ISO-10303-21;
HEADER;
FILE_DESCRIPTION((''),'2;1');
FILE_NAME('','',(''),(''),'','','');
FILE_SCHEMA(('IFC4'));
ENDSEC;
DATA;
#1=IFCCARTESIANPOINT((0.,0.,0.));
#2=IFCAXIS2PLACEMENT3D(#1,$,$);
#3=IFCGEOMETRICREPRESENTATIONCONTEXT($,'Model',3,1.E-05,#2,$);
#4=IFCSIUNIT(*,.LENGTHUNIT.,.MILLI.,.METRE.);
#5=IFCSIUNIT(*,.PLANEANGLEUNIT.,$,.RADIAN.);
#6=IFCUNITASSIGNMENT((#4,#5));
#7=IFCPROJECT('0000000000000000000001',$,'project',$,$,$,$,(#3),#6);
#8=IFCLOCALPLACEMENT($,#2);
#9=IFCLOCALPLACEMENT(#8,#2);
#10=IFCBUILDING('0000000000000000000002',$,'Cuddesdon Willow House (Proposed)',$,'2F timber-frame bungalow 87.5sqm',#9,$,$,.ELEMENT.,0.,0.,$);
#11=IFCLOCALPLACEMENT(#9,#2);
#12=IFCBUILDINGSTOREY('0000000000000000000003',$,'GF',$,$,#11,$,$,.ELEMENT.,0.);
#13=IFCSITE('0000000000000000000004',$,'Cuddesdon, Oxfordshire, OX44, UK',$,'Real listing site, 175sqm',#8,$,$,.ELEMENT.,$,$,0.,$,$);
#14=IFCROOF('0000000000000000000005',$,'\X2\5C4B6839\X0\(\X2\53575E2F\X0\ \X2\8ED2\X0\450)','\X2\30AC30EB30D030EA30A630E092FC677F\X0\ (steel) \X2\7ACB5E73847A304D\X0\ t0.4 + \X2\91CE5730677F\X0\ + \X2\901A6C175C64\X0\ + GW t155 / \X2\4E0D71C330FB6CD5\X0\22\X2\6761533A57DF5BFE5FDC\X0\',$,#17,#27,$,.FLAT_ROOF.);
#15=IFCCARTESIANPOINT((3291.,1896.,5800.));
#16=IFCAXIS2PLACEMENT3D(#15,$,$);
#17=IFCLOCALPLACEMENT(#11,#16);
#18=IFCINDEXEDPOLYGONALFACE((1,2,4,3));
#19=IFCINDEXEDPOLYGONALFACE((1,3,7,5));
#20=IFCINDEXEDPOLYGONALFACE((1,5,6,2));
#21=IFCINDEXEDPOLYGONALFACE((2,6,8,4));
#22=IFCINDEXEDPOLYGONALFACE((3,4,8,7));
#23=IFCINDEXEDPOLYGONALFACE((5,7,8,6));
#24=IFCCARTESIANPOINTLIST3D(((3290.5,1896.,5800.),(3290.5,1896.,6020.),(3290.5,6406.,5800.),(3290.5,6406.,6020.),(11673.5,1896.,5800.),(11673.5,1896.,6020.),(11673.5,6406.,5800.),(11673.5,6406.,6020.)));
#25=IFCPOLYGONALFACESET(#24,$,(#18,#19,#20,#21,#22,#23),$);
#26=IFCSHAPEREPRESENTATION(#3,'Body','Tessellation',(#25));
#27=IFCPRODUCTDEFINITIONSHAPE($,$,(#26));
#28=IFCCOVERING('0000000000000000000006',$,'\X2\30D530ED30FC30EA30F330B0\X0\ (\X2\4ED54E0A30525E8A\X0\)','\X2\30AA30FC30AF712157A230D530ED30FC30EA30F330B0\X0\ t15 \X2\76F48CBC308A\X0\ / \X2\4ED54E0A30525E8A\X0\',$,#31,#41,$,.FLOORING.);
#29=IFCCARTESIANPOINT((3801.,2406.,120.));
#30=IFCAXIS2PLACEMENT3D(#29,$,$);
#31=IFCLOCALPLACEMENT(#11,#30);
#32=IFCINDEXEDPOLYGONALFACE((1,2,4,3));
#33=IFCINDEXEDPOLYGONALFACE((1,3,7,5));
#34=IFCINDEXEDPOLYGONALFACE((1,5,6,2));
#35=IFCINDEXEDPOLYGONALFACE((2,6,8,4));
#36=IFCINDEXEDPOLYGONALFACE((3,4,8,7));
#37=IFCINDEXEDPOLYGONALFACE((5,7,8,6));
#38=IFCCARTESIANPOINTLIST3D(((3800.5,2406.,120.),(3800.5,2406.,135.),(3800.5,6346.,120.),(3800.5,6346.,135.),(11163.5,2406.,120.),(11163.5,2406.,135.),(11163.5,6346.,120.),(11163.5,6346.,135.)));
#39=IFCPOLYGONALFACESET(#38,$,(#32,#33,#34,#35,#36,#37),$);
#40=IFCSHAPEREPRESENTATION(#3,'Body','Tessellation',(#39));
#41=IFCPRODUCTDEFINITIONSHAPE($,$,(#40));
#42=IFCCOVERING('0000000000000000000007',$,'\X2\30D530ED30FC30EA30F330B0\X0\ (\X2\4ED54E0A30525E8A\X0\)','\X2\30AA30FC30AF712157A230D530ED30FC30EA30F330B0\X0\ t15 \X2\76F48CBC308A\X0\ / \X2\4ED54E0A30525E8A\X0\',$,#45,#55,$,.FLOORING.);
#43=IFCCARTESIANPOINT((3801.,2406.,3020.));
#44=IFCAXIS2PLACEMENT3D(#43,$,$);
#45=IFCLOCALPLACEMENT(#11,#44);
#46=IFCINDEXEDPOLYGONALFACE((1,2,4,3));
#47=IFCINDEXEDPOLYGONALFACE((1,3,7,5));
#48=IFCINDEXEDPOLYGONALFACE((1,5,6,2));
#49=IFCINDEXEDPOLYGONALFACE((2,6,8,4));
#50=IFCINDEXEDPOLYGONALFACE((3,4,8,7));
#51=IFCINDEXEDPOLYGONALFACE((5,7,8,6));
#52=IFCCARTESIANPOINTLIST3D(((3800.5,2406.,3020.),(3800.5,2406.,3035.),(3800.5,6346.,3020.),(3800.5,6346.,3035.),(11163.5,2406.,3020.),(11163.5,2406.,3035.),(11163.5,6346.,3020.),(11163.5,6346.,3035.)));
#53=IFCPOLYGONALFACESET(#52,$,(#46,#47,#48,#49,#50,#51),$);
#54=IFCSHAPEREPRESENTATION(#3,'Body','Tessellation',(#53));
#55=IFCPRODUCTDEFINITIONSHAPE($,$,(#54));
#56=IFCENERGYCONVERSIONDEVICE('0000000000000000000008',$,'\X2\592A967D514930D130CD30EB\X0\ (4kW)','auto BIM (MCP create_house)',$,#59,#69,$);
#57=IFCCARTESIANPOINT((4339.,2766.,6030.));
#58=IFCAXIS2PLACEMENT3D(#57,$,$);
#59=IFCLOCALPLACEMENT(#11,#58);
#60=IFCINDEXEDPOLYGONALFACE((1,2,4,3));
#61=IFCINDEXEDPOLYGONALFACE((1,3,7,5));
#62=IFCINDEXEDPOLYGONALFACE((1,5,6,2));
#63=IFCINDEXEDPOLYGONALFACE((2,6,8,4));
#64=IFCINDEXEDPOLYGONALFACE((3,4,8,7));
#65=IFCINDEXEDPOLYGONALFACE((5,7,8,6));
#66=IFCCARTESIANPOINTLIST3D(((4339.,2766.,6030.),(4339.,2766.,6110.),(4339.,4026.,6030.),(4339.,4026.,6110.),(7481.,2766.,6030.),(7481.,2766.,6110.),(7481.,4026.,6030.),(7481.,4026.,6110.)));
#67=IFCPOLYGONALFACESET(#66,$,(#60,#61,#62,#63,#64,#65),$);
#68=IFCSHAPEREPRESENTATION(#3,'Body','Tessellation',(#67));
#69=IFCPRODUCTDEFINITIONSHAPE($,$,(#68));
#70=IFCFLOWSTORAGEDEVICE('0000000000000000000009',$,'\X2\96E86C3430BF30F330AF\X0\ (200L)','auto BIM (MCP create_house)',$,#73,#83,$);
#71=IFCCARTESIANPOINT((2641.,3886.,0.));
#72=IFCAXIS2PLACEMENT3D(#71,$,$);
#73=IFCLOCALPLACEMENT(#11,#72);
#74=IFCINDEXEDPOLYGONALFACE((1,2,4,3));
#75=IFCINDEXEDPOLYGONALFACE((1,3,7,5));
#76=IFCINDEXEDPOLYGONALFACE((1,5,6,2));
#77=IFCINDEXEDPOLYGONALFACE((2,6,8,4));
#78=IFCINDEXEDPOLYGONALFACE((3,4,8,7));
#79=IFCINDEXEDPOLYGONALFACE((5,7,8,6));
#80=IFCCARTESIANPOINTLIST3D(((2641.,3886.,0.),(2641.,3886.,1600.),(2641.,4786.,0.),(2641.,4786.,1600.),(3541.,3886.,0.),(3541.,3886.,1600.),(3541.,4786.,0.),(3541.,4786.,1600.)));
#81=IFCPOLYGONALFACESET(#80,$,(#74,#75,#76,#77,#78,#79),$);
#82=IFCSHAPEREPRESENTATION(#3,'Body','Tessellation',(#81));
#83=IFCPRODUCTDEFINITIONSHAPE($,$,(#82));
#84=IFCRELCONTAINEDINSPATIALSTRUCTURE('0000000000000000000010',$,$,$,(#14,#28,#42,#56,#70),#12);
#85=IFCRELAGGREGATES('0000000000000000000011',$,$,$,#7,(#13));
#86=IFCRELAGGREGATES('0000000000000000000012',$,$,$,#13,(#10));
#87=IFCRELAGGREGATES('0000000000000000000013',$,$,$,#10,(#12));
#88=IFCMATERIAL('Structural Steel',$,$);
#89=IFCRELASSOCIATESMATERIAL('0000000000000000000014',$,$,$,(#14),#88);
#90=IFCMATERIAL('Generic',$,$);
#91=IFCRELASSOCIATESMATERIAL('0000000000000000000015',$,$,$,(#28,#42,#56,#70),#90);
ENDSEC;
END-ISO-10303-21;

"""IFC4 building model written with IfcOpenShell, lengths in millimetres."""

from ifc_helpers import new_model, si_unit, frame, frame_2d, origin, place, context, project, spatial, rectangle, extrude, material, element, save


model = new_model("IFC4")

# Units and contexts
model_context = context("Model", 3, precision=1e-05, world=origin())
ifc_project = project(units=[si_unit("LENGTHUNIT", "METRE", prefix="MILLI"), si_unit("PLANEANGLEUNIT", "RADIAN")], contexts=[model_context])

# Site, building, storey
site_placement = place(None, origin())
site = spatial("IfcSite", under=ifc_project, at=site_placement, Name="Cuddesdon, Oxfordshire, OX44, UK", ObjectType="Real listing site, 175sqm", CompositionType="ELEMENT", RefElevation=0.0)
building_placement = place(site_placement, origin())
building = spatial("IfcBuilding", under=site, at=building_placement, Name="Cuddesdon Willow House (Proposed)", ObjectType="2F timber-frame bungalow 87.5sqm", CompositionType="ELEMENT", ElevationOfRefHeight=0.0, ElevationOfTerrain=0.0)
storey_placement = place(building_placement, origin())
storey = spatial("IfcBuildingStorey", under=building, at=storey_placement, Name="GF", CompositionType="ELEMENT", Elevation=0.0)

# Roof
ifc_material_1 = material(Name="Structural Steel")
for number, where, name in (
    (1, (3291.0, 1896.0, 5800.0), "屋根(南帯 軒450)"),
):
    element("IfcRoof", number, at=place(storey_placement, frame(where)), inside=storey, material=ifc_material_1, Name=name, Description="ガルバリウム鋼板 (steel) 立平葺き t0.4 + 野地板 + 通気層 + GW t155 / 不燃・法22条区域対応", PredefinedType="FLAT_ROOF", context=model_context, shape_type="SweptSolid", body=[
        extrude(rectangle(XDim=8383.0, YDim=4510.0, at=frame_2d((4191.0, 2255.0))), frame((3291.0, 1896.0, 5800.0)), (0.0, 0.0, 1.0), 220.0),
    ])

# Coverings
ifc_material_2 = material(Name="Generic")
covering_1_placement = place(storey_placement, frame((3801.0, 2406.0, 120.0)))
element("IfcCovering", 2, at=covering_1_placement, inside=storey, material=ifc_material_2, Name="フローリング (仕上げ床)", Description="オーク無垢フローリング t15 直貼り / 仕上げ床", PredefinedType="FLOORING", context=model_context, shape_type="SweptSolid", body=[
    extrude(rectangle(XDim=7363.0, YDim=3940.0, at=frame_2d((3681.0, 1970.0))), frame((3801.0, 2406.0, 120.0)), (0.0, 0.0, 1.0), 15.0),
])
covering_2_placement = place(storey_placement, frame((3801.0, 2406.0, 3020.0)))
element("IfcCovering", 3, at=covering_2_placement, inside=storey, material=ifc_material_2, Name="フローリング (仕上げ床)", Description="オーク無垢フローリング t15 直貼り / 仕上げ床", PredefinedType="FLOORING", context=model_context, shape_type="SweptSolid", body=[
    extrude(rectangle(XDim=7363.0, YDim=3940.0, at=frame_2d((3681.0, 1970.0))), frame((3801.0, 2406.0, 3020.0)), (0.0, 0.0, 1.0), 15.0),
])

# Energy conversion device
energy_conversion_device_placement = place(storey_placement, frame((4339.0, 2766.0, 6030.0)))
element("IfcEnergyConversionDevice", 4, at=energy_conversion_device_placement, inside=storey, material=ifc_material_2, Name="太陽光パネル (4kW)", Description="auto BIM (MCP create_house)", context=model_context, shape_type="SweptSolid", body=[
    extrude(rectangle(XDim=3142.0, YDim=1260.0, at=frame_2d((1571.0, 630.0))), frame((4339.0, 2766.0, 6030.0)), (0.0, 0.0, 1.0), 80.0),
])

# Flow storage device
flow_storage_device_placement = place(storey_placement, frame((2641.0, 3886.0, 0.0)))
element("IfcFlowStorageDevice", 5, at=flow_storage_device_placement, inside=storey, material=ifc_material_2, Name="雨水タンク (200L)", Description="auto BIM (MCP create_house)", context=model_context, shape_type="SweptSolid", body=[
    extrude(rectangle(XDim=900.0, YDim=900.0, at=frame_2d((450.0, 450.0))), frame((2641.0, 3886.0, 0.0)), (0.0, 0.0, 1.0), 1600.0),
])

save(model, "model.ifc")
